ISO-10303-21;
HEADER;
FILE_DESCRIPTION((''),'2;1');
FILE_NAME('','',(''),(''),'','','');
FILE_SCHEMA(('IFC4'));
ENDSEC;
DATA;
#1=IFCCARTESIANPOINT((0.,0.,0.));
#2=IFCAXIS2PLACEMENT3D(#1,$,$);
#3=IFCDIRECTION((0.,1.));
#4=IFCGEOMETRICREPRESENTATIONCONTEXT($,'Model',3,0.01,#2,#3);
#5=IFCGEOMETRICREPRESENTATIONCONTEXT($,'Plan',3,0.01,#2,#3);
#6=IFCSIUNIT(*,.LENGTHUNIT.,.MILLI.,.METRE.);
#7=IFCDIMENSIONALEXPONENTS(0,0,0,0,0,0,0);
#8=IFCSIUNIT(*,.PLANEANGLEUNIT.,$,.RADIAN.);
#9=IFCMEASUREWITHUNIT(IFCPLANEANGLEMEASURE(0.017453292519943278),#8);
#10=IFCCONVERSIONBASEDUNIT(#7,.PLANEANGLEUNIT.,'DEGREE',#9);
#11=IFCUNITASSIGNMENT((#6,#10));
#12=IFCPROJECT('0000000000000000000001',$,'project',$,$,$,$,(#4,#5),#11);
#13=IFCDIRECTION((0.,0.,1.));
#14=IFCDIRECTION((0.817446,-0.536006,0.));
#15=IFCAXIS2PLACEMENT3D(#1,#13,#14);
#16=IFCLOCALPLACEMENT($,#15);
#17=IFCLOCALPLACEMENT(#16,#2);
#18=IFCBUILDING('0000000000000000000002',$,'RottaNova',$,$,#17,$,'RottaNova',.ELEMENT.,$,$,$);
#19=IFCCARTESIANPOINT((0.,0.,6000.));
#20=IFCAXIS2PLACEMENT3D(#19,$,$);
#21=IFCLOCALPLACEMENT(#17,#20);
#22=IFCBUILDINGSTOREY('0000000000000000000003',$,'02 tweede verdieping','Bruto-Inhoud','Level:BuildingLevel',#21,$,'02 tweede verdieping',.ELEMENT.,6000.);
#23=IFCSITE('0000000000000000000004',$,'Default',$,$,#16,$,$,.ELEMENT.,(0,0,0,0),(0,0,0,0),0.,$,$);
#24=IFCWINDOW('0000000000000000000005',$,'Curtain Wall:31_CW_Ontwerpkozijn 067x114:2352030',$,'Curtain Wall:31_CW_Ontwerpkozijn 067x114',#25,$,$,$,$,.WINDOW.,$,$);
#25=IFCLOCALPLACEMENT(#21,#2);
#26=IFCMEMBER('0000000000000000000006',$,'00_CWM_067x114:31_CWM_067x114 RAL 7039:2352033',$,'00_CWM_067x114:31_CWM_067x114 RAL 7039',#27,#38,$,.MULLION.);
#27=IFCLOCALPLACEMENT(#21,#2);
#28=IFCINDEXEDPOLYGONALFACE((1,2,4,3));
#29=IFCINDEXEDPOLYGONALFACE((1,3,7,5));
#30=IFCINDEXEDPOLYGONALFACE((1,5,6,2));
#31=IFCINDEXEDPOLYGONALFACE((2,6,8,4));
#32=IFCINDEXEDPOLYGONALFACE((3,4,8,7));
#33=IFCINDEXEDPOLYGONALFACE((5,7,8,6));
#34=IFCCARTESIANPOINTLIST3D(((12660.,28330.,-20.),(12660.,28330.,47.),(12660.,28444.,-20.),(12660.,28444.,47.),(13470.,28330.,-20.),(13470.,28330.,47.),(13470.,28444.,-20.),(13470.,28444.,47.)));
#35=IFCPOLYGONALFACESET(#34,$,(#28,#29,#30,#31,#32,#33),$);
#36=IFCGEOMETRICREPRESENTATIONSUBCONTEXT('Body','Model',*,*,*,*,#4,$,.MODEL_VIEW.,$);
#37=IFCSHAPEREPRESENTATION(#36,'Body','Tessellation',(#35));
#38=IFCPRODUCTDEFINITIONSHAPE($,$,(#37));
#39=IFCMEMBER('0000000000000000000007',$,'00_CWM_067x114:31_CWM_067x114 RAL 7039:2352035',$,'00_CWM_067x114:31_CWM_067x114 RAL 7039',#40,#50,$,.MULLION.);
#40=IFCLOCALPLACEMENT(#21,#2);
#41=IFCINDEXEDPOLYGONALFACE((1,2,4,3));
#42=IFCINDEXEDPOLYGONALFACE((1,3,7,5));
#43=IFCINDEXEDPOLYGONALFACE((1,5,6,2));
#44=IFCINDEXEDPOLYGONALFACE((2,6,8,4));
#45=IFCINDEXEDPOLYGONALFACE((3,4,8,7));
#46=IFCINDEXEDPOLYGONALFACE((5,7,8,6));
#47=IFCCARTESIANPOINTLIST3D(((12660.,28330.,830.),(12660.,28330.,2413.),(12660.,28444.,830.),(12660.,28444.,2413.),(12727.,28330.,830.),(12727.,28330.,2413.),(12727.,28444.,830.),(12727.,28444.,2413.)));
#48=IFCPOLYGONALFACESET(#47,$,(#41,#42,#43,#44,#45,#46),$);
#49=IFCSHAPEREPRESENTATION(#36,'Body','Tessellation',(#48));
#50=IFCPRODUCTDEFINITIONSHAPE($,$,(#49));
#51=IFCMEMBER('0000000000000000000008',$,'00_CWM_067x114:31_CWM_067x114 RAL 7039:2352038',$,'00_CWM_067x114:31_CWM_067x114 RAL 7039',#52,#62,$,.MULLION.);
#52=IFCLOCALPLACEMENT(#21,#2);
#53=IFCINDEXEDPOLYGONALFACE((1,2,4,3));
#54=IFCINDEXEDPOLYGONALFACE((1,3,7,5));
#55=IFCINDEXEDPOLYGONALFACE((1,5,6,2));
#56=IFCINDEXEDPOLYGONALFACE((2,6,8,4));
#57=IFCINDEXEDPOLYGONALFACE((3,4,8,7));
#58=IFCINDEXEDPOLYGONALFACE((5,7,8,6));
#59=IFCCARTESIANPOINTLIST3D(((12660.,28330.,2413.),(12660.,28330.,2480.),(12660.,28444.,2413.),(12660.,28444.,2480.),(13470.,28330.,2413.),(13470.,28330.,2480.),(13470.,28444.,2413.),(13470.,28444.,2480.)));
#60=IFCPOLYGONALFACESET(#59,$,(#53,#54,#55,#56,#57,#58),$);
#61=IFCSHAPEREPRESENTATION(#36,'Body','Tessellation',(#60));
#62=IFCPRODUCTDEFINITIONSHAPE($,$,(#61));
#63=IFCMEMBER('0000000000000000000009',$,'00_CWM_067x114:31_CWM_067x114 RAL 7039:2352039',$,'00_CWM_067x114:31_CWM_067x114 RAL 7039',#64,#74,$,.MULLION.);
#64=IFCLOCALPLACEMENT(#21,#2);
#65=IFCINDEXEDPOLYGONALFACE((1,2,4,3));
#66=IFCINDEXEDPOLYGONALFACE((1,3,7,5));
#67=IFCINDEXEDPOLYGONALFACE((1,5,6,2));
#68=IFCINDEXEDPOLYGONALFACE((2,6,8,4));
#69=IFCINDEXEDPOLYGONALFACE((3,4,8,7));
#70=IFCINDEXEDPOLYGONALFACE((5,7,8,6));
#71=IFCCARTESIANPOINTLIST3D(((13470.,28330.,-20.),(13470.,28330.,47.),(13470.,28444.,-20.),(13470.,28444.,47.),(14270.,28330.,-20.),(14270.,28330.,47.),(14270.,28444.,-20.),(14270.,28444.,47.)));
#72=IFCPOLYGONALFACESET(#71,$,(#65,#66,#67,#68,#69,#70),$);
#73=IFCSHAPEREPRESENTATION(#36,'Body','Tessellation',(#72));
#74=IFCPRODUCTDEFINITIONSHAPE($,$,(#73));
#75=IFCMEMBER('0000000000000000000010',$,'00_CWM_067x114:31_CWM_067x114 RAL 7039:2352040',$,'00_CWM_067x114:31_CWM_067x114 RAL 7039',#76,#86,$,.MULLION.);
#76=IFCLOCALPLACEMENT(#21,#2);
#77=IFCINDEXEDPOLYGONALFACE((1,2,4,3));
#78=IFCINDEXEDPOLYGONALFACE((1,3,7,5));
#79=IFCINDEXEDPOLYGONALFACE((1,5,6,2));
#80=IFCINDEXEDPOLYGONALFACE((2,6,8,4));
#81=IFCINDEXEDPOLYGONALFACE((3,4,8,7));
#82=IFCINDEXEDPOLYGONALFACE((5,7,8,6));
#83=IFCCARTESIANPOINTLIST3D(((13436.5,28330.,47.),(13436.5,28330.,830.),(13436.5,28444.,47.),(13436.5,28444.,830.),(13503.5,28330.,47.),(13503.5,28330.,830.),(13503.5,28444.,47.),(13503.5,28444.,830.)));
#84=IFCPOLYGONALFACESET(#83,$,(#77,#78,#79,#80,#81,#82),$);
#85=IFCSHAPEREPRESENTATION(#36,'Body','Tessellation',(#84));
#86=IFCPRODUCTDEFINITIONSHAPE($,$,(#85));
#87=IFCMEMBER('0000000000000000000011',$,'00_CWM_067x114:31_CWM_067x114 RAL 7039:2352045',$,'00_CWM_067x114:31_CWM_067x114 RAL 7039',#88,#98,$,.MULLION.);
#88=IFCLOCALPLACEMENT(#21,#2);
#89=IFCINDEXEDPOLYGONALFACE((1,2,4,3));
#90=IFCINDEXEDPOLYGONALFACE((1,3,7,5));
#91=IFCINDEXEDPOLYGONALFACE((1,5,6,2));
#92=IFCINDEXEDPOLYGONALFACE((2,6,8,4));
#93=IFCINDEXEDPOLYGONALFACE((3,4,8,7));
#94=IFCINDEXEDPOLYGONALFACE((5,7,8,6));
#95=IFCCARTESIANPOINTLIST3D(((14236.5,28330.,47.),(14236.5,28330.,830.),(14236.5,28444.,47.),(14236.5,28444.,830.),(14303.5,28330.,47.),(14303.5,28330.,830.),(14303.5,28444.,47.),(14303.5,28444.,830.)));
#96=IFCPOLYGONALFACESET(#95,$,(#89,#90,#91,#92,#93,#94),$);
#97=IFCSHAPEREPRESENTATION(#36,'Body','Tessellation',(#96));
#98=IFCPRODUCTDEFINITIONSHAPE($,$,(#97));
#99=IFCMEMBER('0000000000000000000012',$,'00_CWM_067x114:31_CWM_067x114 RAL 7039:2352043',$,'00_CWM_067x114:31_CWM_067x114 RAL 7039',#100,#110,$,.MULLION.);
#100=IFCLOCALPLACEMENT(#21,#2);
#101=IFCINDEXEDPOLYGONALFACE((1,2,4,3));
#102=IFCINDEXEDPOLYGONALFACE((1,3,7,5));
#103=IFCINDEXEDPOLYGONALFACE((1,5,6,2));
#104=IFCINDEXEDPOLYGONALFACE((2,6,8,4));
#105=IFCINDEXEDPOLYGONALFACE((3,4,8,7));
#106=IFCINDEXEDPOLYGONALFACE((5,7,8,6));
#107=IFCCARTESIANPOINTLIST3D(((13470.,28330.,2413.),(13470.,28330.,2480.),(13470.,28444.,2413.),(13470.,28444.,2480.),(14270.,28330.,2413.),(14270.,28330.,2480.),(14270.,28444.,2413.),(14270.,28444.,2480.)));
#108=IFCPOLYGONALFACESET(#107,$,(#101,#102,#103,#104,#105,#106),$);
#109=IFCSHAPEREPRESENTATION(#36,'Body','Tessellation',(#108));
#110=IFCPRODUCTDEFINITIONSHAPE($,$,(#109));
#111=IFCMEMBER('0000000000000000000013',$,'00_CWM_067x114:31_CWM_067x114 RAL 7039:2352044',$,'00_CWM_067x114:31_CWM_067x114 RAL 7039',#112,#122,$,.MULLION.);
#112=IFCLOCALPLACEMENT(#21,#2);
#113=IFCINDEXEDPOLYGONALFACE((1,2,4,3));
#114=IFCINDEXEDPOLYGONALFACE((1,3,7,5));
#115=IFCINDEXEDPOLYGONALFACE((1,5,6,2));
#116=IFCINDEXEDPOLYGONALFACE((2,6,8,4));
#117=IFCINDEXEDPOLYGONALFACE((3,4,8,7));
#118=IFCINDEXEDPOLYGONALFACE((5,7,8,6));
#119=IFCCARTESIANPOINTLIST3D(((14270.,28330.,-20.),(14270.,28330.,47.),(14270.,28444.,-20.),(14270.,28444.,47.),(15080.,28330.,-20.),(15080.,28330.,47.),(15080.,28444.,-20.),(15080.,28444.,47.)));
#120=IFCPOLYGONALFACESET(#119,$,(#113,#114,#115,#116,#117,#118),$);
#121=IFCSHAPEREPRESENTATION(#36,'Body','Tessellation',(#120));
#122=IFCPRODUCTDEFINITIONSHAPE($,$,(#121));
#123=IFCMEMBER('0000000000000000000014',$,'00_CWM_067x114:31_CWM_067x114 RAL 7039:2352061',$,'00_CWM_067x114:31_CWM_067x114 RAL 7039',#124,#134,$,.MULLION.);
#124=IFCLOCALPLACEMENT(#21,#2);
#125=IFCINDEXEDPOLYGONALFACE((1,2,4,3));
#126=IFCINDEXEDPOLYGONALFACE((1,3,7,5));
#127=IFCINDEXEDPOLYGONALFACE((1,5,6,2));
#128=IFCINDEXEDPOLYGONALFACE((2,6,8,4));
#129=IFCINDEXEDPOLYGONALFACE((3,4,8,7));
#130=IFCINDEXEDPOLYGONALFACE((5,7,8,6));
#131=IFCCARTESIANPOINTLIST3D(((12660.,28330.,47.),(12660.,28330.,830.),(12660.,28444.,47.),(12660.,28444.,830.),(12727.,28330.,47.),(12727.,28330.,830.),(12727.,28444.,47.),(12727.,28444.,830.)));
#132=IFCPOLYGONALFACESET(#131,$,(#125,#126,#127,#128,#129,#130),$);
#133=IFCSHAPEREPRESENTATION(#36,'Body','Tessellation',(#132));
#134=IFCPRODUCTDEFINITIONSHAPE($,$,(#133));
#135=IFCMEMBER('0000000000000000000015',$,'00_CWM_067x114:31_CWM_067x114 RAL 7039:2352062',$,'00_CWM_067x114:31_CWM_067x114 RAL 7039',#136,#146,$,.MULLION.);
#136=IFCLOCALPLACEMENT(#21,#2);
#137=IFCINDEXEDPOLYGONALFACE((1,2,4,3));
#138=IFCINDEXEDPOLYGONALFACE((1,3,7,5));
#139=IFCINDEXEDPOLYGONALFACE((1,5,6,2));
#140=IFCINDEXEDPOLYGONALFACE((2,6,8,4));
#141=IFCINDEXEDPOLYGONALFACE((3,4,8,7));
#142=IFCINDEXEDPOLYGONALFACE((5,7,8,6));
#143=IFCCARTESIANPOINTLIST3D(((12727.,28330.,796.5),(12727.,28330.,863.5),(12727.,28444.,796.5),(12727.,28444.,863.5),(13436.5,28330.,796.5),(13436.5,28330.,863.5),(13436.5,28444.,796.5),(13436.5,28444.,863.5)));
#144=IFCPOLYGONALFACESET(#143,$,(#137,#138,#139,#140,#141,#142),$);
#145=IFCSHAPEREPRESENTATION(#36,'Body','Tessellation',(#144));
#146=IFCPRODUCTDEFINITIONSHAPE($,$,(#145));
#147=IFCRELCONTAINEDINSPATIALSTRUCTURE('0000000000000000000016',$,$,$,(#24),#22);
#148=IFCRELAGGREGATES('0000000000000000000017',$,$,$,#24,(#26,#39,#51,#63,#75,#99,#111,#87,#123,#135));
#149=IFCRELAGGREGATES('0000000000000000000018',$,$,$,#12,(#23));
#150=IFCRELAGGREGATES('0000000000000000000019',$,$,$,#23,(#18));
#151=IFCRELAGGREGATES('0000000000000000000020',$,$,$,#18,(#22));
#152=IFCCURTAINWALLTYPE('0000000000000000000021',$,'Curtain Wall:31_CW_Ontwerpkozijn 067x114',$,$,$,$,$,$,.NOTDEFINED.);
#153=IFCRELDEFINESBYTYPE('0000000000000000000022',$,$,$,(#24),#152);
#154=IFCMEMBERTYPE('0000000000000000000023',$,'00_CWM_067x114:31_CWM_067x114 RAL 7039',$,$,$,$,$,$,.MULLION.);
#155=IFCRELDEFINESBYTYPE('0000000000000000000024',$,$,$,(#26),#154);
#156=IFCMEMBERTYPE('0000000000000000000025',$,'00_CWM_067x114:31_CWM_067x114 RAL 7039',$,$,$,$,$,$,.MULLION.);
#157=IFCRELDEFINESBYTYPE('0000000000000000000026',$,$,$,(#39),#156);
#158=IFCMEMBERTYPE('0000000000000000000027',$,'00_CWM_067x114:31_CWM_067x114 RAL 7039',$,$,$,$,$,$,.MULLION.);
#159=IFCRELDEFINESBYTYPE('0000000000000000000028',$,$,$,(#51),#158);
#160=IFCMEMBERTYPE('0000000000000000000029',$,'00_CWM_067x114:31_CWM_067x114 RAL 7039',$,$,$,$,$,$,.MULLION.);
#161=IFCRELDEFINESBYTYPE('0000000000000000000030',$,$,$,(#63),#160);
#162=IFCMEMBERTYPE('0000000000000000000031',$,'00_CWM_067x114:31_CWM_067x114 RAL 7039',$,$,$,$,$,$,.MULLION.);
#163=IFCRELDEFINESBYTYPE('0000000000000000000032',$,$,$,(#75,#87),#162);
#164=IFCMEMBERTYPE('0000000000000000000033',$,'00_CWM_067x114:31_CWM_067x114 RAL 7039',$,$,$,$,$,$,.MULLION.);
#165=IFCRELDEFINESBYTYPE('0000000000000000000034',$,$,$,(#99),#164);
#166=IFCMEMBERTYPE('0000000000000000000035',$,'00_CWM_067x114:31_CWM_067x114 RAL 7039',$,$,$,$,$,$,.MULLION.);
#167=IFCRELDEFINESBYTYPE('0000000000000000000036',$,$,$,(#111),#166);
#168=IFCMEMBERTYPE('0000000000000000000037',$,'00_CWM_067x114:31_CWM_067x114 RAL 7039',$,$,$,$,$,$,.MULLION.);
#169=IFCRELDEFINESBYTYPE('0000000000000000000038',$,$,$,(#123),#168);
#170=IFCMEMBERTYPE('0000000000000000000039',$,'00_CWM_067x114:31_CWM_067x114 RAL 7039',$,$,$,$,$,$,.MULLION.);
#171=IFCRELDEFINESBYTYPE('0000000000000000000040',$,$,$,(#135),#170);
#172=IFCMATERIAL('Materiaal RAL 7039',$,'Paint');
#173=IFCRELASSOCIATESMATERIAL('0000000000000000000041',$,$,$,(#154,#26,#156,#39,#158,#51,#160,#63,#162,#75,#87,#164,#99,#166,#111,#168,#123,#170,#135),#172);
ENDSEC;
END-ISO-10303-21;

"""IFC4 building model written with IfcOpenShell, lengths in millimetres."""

from ifc_helpers import new_model, entity, si_unit, converted_unit, direction, frame, origin, place, context, subcontext, project, spatial, indexed_curve, outline, extrude, source, transform, mapped, material, type_object, type_shapes, element, aggregate, save


model = new_model("IFC4")

# Units and contexts
model_context = context("Model", 3, precision=0.01, world=origin(), true_north=direction((0.0, 1.0)))
plan_context = context("Plan", 3, precision=0.01, world=origin(), true_north=direction((0.0, 1.0)))
body_context = subcontext(model_context, "Body", "Model", "MODEL_VIEW")
ifc_project = project(units=[si_unit("LENGTHUNIT", "METRE", prefix="MILLI"), converted_unit("PLANEANGLEUNIT", "DEGREE", entity("IfcPlaneAngleMeasure", 0.017453292519943278), si_unit("PLANEANGLEUNIT", "RADIAN"), dimensions=[0, 0, 0, 0, 0, 0, 0])], contexts=[model_context, plan_context])

# Site, building, storey
site_placement = place(None, frame((0.0, 0.0, 0.0), z_axis=(0.0, 0.0, 1.0), x_axis=(0.817446, -0.536006, 0.0)))
site = spatial("IfcSite", under=ifc_project, at=site_placement, Name="Default", CompositionType="ELEMENT", RefLatitude=(0, 0, 0, 0), RefLongitude=(0, 0, 0, 0), RefElevation=0.0)
building_placement = place(site_placement, origin())
building = spatial("IfcBuilding", under=site, at=building_placement, Name="RottaNova", LongName="RottaNova", CompositionType="ELEMENT")
storey_placement = place(building_placement, frame((0.0, 0.0, 6000.0)))
storey = spatial("IfcBuildingStorey", under=building, at=storey_placement, Name="02 tweede verdieping", Description="Bruto-Inhoud", ObjectType="Level:BuildingLevel", LongName="02 tweede verdieping", CompositionType="ELEMENT", Elevation=6000.0)

# Window, members
curtain_wall_type = type_object("IfcCurtainWallType", Name="Curtain Wall:31_CW_Ontwerpkozijn 067x114", PredefinedType="NOTDEFINED")
window_1_placement = place(storey_placement, frame((0.0, 0.0, -6000.0)))
window_1 = element("IfcWindow", 1, at=window_1_placement, inside=storey, type_object=curtain_wall_type, Name="Curtain Wall:31_CW_Ontwerpkozijn 067x114:2352030", ObjectType="Curtain Wall:31_CW_Ontwerpkozijn 067x114", PredefinedType="WINDOW")
ifc_material_1 = material(Name="Materiaal RAL 7039", Category="Paint")
member_type_1 = type_object("IfcMemberType", Name="00_CWM_067x114:31_CWM_067x114 RAL 7039", PredefinedType="MULLION", material=ifc_material_1)
shared_shape_1 = source(origin(), body_context, "Body", "SweptSolid", [
    extrude(outline(indexed_curve([(-33.5, -57.0), (33.5, -57.0), (33.5, 57.0), (-33.5, 57.0), (-33.5, -57.0)], self_intersect=False)), frame((-33.5, -57.0, -810.0), z_axis=(0.0, 0.0, 1.0), x_axis=(-1.0, 0.0, 0.0)), (0.0, 0.0, 1.0), 810.0),
])
type_shapes(member_type_1, [shared_shape_1])
member_1_placement = place(window_1_placement, frame((12660.0, 28330.0, 5980.0), z_axis=(-1.0, 0.0, 0.0), x_axis=(0.0, 0.0, -1.0)))
member_1 = element("IfcMember", 2, at=member_1_placement, type_object=member_type_1, material=ifc_material_1, Name="00_CWM_067x114:31_CWM_067x114 RAL 7039:2352033", ObjectType="00_CWM_067x114:31_CWM_067x114 RAL 7039", PredefinedType="MULLION", context=body_context, shape_type="MappedRepresentation", body=[
    mapped(shared_shape_1, transform((0.0, 0.0, 0.0), scale=1.0)),
])
member_type_2 = type_object("IfcMemberType", Name="00_CWM_067x114:31_CWM_067x114 RAL 7039", PredefinedType="MULLION", material=ifc_material_1)
shared_shape_2 = source(origin(), body_context, "Body", "SweptSolid", [
    extrude(outline(indexed_curve([(-33.5, -57.0), (33.5, -57.0), (33.5, 57.0), (-33.5, 57.0), (-33.5, -57.0)], self_intersect=False)), frame((-33.5, -57.0, -1583.0), z_axis=(0.0, 0.0, 1.0), x_axis=(-1.0, 0.0, 0.0)), (0.0, 0.0, 1.0), 1583.0),
])
type_shapes(member_type_2, [shared_shape_2])
member_2_placement = place(window_1_placement, frame((12660.0, 28330.0, 8413.0), z_axis=(0.0, 0.0, 1.0), x_axis=(-1.0, 0.0, 0.0)))
member_2 = element("IfcMember", 3, at=member_2_placement, type_object=member_type_2, material=ifc_material_1, Name="00_CWM_067x114:31_CWM_067x114 RAL 7039:2352035", ObjectType="00_CWM_067x114:31_CWM_067x114 RAL 7039", PredefinedType="MULLION", context=body_context, shape_type="MappedRepresentation", body=[
    mapped(shared_shape_2, transform((0.0, 0.0, 0.0), scale=1.0)),
])
member_type_3 = type_object("IfcMemberType", Name="00_CWM_067x114:31_CWM_067x114 RAL 7039", PredefinedType="MULLION", material=ifc_material_1)
shared_shape_3 = source(origin(), body_context, "Body", "SweptSolid", [
    extrude(outline(indexed_curve([(-33.5, -57.0), (33.5, -57.0), (33.5, 57.0), (-33.5, 57.0), (-33.5, -57.0)], self_intersect=False)), frame((-33.5, -57.0, -810.0), z_axis=(0.0, 0.0, 1.0), x_axis=(-1.0, 0.0, 0.0)), (0.0, 0.0, 1.0), 810.0),
])
type_shapes(member_type_3, [shared_shape_3])
member_3_placement = place(window_1_placement, frame((13470.0, 28330.0, 8480.0), z_axis=(1.0, 0.0, 0.0), x_axis=(0.0, 0.0, 1.0)))
member_3 = element("IfcMember", 4, at=member_3_placement, type_object=member_type_3, material=ifc_material_1, Name="00_CWM_067x114:31_CWM_067x114 RAL 7039:2352038", ObjectType="00_CWM_067x114:31_CWM_067x114 RAL 7039", PredefinedType="MULLION", context=body_context, shape_type="MappedRepresentation", body=[
    mapped(shared_shape_3, transform((0.0, 0.0, 0.0), scale=1.0)),
])
member_type_4 = type_object("IfcMemberType", Name="00_CWM_067x114:31_CWM_067x114 RAL 7039", PredefinedType="MULLION", material=ifc_material_1)
shared_shape_4 = source(origin(), body_context, "Body", "SweptSolid", [
    extrude(outline(indexed_curve([(-33.5, -57.0), (33.5, -57.0), (33.5, 57.0), (-33.5, 57.0), (-33.5, -57.0)], self_intersect=False)), frame((-33.5, -57.0, -800.0), z_axis=(0.0, 0.0, 1.0), x_axis=(-1.0, 0.0, 0.0)), (0.0, 0.0, 1.0), 800.0),
])
type_shapes(member_type_4, [shared_shape_4])
member_4_placement = place(window_1_placement, frame((13470.0, 28330.0, 5980.0), z_axis=(-1.0, 0.0, 0.0), x_axis=(0.0, 0.0, -1.0)))
member_4 = element("IfcMember", 5, at=member_4_placement, type_object=member_type_4, material=ifc_material_1, Name="00_CWM_067x114:31_CWM_067x114 RAL 7039:2352039", ObjectType="00_CWM_067x114:31_CWM_067x114 RAL 7039", PredefinedType="MULLION", context=body_context, shape_type="MappedRepresentation", body=[
    mapped(shared_shape_4, transform((0.0, 0.0, 0.0), scale=1.0)),
])
member_type_5 = type_object("IfcMemberType", Name="00_CWM_067x114:31_CWM_067x114 RAL 7039", PredefinedType="MULLION", material=ifc_material_1)
shared_shape_5 = source(origin(), body_context, "Body", "SweptSolid", [
    extrude(outline(indexed_curve([(-33.5, -57.0), (33.5, -57.0), (33.5, 57.0), (-33.5, 57.0), (-33.5, -57.0)], self_intersect=False)), frame((0.0, -57.0, -783.0), z_axis=(0.0, 0.0, 1.0), x_axis=(-1.0, 0.0, 0.0)), (0.0, 0.0, 1.0), 783.0),
])
type_shapes(member_type_5, [shared_shape_5])
member_5_placement = place(window_1_placement, frame((13470.0, 28330.0, 6047.0), z_axis=(0.0, 0.0, -1.0), x_axis=(1.0, 0.0, 0.0)))
member_5 = element("IfcMember", 6, at=member_5_placement, type_object=member_type_5, material=ifc_material_1, Name="00_CWM_067x114:31_CWM_067x114 RAL 7039:2352040", ObjectType="00_CWM_067x114:31_CWM_067x114 RAL 7039", PredefinedType="MULLION", context=body_context, shape_type="MappedRepresentation", body=[
    mapped(shared_shape_5, transform((0.0, 0.0, 0.0), scale=1.0)),
])
member_6_placement = place(window_1_placement, frame((14270.0, 28330.0, 6047.0), z_axis=(0.0, 0.0, -1.0), x_axis=(1.0, 0.0, 0.0)))
member_6 = element("IfcMember", 7, at=member_6_placement, type_object=member_type_5, material=ifc_material_1, Name="00_CWM_067x114:31_CWM_067x114 RAL 7039:2352045", ObjectType="00_CWM_067x114:31_CWM_067x114 RAL 7039", PredefinedType="MULLION", context=body_context, shape_type="MappedRepresentation", body=[
    mapped(shared_shape_5, transform((0.0, 0.0, 0.0), scale=1.0)),
])
member_type_6 = type_object("IfcMemberType", Name="00_CWM_067x114:31_CWM_067x114 RAL 7039", PredefinedType="MULLION", material=ifc_material_1)
shared_shape_6 = source(origin(), body_context, "Body", "SweptSolid", [
    extrude(outline(indexed_curve([(-33.5, -57.0), (33.5, -57.0), (33.5, 57.0), (-33.5, 57.0), (-33.5, -57.0)], self_intersect=False)), frame((-33.5, -57.0, -800.0), z_axis=(0.0, 0.0, 1.0), x_axis=(-1.0, 0.0, 0.0)), (0.0, 0.0, 1.0), 800.0),
])
type_shapes(member_type_6, [shared_shape_6])
member_7_placement = place(window_1_placement, frame((14270.0, 28330.0, 8480.0), z_axis=(1.0, 0.0, 0.0), x_axis=(0.0, 0.0, 1.0)))
member_7 = element("IfcMember", 8, at=member_7_placement, type_object=member_type_6, material=ifc_material_1, Name="00_CWM_067x114:31_CWM_067x114 RAL 7039:2352043", ObjectType="00_CWM_067x114:31_CWM_067x114 RAL 7039", PredefinedType="MULLION", context=body_context, shape_type="MappedRepresentation", body=[
    mapped(shared_shape_6, transform((0.0, 0.0, 0.0), scale=1.0)),
])
member_type_7 = type_object("IfcMemberType", Name="00_CWM_067x114:31_CWM_067x114 RAL 7039", PredefinedType="MULLION", material=ifc_material_1)
shared_shape_7 = source(origin(), body_context, "Body", "SweptSolid", [
    extrude(outline(indexed_curve([(-33.5, -57.0), (33.5, -57.0), (33.5, 57.0), (-33.5, 57.0), (-33.5, -57.0)], self_intersect=False)), frame((-33.5, -57.0, -810.0), z_axis=(0.0, 0.0, 1.0), x_axis=(-1.0, 0.0, 0.0)), (0.0, 0.0, 1.0), 810.0),
])
type_shapes(member_type_7, [shared_shape_7])
member_8_placement = place(window_1_placement, frame((14270.0, 28330.0, 5980.0), z_axis=(-1.0, 0.0, 0.0), x_axis=(0.0, 0.0, -1.0)))
member_8 = element("IfcMember", 9, at=member_8_placement, type_object=member_type_7, material=ifc_material_1, Name="00_CWM_067x114:31_CWM_067x114 RAL 7039:2352044", ObjectType="00_CWM_067x114:31_CWM_067x114 RAL 7039", PredefinedType="MULLION", context=body_context, shape_type="MappedRepresentation", body=[
    mapped(shared_shape_7, transform((0.0, 0.0, 0.0), scale=1.0)),
])
member_type_8 = type_object("IfcMemberType", Name="00_CWM_067x114:31_CWM_067x114 RAL 7039", PredefinedType="MULLION", material=ifc_material_1)
shared_shape_8 = source(origin(), body_context, "Body", "SweptSolid", [
    extrude(outline(indexed_curve([(-33.5, -57.0), (33.5, -57.0), (33.5, 57.0), (-33.5, 57.0), (-33.5, -57.0)], self_intersect=False)), frame((-33.5, -57.0, -783.0), z_axis=(0.0, 0.0, 1.0), x_axis=(-1.0, 0.0, 0.0)), (0.0, 0.0, 1.0), 783.0),
])
type_shapes(member_type_8, [shared_shape_8])
member_9_placement = place(window_1_placement, frame((12660.0, 28330.0, 6830.0), z_axis=(0.0, 0.0, 1.0), x_axis=(-1.0, 0.0, 0.0)))
member_9 = element("IfcMember", 10, at=member_9_placement, type_object=member_type_8, material=ifc_material_1, Name="00_CWM_067x114:31_CWM_067x114 RAL 7039:2352061", ObjectType="00_CWM_067x114:31_CWM_067x114 RAL 7039", PredefinedType="MULLION", context=body_context, shape_type="MappedRepresentation", body=[
    mapped(shared_shape_8, transform((0.0, 0.0, 0.0), scale=1.0)),
])
member_type_9 = type_object("IfcMemberType", Name="00_CWM_067x114:31_CWM_067x114 RAL 7039", PredefinedType="MULLION", material=ifc_material_1)
shared_shape_9 = source(origin(), body_context, "Body", "SweptSolid", [
    extrude(outline(indexed_curve([(-33.5, -57.0), (33.5, -57.0), (33.5, 57.0), (-33.5, 57.0), (-33.5, -57.0)], self_intersect=False)), frame((0.0, -57.0, -709.5), z_axis=(0.0, 0.0, 1.0), x_axis=(-1.0, 0.0, 0.0)), (0.0, 0.0, 1.0), 709.5),
])
type_shapes(member_type_9, [shared_shape_9])
member_10_placement = place(window_1_placement, frame((13436.5, 28330.0, 6830.0), z_axis=(1.0, 0.0, 0.0), x_axis=(0.0, 0.0, 1.0)))
member_10 = element("IfcMember", 11, at=member_10_placement, type_object=member_type_9, material=ifc_material_1, Name="00_CWM_067x114:31_CWM_067x114 RAL 7039:2352062", ObjectType="00_CWM_067x114:31_CWM_067x114 RAL 7039", PredefinedType="MULLION", context=body_context, shape_type="MappedRepresentation", body=[
    mapped(shared_shape_9, transform((0.0, 0.0, 0.0), scale=1.0)),
])

aggregate(window_1, [member_1, member_2, member_3, member_4, member_5, member_7, member_8, member_6, member_9, member_10])

save(model, "model.ifc")
